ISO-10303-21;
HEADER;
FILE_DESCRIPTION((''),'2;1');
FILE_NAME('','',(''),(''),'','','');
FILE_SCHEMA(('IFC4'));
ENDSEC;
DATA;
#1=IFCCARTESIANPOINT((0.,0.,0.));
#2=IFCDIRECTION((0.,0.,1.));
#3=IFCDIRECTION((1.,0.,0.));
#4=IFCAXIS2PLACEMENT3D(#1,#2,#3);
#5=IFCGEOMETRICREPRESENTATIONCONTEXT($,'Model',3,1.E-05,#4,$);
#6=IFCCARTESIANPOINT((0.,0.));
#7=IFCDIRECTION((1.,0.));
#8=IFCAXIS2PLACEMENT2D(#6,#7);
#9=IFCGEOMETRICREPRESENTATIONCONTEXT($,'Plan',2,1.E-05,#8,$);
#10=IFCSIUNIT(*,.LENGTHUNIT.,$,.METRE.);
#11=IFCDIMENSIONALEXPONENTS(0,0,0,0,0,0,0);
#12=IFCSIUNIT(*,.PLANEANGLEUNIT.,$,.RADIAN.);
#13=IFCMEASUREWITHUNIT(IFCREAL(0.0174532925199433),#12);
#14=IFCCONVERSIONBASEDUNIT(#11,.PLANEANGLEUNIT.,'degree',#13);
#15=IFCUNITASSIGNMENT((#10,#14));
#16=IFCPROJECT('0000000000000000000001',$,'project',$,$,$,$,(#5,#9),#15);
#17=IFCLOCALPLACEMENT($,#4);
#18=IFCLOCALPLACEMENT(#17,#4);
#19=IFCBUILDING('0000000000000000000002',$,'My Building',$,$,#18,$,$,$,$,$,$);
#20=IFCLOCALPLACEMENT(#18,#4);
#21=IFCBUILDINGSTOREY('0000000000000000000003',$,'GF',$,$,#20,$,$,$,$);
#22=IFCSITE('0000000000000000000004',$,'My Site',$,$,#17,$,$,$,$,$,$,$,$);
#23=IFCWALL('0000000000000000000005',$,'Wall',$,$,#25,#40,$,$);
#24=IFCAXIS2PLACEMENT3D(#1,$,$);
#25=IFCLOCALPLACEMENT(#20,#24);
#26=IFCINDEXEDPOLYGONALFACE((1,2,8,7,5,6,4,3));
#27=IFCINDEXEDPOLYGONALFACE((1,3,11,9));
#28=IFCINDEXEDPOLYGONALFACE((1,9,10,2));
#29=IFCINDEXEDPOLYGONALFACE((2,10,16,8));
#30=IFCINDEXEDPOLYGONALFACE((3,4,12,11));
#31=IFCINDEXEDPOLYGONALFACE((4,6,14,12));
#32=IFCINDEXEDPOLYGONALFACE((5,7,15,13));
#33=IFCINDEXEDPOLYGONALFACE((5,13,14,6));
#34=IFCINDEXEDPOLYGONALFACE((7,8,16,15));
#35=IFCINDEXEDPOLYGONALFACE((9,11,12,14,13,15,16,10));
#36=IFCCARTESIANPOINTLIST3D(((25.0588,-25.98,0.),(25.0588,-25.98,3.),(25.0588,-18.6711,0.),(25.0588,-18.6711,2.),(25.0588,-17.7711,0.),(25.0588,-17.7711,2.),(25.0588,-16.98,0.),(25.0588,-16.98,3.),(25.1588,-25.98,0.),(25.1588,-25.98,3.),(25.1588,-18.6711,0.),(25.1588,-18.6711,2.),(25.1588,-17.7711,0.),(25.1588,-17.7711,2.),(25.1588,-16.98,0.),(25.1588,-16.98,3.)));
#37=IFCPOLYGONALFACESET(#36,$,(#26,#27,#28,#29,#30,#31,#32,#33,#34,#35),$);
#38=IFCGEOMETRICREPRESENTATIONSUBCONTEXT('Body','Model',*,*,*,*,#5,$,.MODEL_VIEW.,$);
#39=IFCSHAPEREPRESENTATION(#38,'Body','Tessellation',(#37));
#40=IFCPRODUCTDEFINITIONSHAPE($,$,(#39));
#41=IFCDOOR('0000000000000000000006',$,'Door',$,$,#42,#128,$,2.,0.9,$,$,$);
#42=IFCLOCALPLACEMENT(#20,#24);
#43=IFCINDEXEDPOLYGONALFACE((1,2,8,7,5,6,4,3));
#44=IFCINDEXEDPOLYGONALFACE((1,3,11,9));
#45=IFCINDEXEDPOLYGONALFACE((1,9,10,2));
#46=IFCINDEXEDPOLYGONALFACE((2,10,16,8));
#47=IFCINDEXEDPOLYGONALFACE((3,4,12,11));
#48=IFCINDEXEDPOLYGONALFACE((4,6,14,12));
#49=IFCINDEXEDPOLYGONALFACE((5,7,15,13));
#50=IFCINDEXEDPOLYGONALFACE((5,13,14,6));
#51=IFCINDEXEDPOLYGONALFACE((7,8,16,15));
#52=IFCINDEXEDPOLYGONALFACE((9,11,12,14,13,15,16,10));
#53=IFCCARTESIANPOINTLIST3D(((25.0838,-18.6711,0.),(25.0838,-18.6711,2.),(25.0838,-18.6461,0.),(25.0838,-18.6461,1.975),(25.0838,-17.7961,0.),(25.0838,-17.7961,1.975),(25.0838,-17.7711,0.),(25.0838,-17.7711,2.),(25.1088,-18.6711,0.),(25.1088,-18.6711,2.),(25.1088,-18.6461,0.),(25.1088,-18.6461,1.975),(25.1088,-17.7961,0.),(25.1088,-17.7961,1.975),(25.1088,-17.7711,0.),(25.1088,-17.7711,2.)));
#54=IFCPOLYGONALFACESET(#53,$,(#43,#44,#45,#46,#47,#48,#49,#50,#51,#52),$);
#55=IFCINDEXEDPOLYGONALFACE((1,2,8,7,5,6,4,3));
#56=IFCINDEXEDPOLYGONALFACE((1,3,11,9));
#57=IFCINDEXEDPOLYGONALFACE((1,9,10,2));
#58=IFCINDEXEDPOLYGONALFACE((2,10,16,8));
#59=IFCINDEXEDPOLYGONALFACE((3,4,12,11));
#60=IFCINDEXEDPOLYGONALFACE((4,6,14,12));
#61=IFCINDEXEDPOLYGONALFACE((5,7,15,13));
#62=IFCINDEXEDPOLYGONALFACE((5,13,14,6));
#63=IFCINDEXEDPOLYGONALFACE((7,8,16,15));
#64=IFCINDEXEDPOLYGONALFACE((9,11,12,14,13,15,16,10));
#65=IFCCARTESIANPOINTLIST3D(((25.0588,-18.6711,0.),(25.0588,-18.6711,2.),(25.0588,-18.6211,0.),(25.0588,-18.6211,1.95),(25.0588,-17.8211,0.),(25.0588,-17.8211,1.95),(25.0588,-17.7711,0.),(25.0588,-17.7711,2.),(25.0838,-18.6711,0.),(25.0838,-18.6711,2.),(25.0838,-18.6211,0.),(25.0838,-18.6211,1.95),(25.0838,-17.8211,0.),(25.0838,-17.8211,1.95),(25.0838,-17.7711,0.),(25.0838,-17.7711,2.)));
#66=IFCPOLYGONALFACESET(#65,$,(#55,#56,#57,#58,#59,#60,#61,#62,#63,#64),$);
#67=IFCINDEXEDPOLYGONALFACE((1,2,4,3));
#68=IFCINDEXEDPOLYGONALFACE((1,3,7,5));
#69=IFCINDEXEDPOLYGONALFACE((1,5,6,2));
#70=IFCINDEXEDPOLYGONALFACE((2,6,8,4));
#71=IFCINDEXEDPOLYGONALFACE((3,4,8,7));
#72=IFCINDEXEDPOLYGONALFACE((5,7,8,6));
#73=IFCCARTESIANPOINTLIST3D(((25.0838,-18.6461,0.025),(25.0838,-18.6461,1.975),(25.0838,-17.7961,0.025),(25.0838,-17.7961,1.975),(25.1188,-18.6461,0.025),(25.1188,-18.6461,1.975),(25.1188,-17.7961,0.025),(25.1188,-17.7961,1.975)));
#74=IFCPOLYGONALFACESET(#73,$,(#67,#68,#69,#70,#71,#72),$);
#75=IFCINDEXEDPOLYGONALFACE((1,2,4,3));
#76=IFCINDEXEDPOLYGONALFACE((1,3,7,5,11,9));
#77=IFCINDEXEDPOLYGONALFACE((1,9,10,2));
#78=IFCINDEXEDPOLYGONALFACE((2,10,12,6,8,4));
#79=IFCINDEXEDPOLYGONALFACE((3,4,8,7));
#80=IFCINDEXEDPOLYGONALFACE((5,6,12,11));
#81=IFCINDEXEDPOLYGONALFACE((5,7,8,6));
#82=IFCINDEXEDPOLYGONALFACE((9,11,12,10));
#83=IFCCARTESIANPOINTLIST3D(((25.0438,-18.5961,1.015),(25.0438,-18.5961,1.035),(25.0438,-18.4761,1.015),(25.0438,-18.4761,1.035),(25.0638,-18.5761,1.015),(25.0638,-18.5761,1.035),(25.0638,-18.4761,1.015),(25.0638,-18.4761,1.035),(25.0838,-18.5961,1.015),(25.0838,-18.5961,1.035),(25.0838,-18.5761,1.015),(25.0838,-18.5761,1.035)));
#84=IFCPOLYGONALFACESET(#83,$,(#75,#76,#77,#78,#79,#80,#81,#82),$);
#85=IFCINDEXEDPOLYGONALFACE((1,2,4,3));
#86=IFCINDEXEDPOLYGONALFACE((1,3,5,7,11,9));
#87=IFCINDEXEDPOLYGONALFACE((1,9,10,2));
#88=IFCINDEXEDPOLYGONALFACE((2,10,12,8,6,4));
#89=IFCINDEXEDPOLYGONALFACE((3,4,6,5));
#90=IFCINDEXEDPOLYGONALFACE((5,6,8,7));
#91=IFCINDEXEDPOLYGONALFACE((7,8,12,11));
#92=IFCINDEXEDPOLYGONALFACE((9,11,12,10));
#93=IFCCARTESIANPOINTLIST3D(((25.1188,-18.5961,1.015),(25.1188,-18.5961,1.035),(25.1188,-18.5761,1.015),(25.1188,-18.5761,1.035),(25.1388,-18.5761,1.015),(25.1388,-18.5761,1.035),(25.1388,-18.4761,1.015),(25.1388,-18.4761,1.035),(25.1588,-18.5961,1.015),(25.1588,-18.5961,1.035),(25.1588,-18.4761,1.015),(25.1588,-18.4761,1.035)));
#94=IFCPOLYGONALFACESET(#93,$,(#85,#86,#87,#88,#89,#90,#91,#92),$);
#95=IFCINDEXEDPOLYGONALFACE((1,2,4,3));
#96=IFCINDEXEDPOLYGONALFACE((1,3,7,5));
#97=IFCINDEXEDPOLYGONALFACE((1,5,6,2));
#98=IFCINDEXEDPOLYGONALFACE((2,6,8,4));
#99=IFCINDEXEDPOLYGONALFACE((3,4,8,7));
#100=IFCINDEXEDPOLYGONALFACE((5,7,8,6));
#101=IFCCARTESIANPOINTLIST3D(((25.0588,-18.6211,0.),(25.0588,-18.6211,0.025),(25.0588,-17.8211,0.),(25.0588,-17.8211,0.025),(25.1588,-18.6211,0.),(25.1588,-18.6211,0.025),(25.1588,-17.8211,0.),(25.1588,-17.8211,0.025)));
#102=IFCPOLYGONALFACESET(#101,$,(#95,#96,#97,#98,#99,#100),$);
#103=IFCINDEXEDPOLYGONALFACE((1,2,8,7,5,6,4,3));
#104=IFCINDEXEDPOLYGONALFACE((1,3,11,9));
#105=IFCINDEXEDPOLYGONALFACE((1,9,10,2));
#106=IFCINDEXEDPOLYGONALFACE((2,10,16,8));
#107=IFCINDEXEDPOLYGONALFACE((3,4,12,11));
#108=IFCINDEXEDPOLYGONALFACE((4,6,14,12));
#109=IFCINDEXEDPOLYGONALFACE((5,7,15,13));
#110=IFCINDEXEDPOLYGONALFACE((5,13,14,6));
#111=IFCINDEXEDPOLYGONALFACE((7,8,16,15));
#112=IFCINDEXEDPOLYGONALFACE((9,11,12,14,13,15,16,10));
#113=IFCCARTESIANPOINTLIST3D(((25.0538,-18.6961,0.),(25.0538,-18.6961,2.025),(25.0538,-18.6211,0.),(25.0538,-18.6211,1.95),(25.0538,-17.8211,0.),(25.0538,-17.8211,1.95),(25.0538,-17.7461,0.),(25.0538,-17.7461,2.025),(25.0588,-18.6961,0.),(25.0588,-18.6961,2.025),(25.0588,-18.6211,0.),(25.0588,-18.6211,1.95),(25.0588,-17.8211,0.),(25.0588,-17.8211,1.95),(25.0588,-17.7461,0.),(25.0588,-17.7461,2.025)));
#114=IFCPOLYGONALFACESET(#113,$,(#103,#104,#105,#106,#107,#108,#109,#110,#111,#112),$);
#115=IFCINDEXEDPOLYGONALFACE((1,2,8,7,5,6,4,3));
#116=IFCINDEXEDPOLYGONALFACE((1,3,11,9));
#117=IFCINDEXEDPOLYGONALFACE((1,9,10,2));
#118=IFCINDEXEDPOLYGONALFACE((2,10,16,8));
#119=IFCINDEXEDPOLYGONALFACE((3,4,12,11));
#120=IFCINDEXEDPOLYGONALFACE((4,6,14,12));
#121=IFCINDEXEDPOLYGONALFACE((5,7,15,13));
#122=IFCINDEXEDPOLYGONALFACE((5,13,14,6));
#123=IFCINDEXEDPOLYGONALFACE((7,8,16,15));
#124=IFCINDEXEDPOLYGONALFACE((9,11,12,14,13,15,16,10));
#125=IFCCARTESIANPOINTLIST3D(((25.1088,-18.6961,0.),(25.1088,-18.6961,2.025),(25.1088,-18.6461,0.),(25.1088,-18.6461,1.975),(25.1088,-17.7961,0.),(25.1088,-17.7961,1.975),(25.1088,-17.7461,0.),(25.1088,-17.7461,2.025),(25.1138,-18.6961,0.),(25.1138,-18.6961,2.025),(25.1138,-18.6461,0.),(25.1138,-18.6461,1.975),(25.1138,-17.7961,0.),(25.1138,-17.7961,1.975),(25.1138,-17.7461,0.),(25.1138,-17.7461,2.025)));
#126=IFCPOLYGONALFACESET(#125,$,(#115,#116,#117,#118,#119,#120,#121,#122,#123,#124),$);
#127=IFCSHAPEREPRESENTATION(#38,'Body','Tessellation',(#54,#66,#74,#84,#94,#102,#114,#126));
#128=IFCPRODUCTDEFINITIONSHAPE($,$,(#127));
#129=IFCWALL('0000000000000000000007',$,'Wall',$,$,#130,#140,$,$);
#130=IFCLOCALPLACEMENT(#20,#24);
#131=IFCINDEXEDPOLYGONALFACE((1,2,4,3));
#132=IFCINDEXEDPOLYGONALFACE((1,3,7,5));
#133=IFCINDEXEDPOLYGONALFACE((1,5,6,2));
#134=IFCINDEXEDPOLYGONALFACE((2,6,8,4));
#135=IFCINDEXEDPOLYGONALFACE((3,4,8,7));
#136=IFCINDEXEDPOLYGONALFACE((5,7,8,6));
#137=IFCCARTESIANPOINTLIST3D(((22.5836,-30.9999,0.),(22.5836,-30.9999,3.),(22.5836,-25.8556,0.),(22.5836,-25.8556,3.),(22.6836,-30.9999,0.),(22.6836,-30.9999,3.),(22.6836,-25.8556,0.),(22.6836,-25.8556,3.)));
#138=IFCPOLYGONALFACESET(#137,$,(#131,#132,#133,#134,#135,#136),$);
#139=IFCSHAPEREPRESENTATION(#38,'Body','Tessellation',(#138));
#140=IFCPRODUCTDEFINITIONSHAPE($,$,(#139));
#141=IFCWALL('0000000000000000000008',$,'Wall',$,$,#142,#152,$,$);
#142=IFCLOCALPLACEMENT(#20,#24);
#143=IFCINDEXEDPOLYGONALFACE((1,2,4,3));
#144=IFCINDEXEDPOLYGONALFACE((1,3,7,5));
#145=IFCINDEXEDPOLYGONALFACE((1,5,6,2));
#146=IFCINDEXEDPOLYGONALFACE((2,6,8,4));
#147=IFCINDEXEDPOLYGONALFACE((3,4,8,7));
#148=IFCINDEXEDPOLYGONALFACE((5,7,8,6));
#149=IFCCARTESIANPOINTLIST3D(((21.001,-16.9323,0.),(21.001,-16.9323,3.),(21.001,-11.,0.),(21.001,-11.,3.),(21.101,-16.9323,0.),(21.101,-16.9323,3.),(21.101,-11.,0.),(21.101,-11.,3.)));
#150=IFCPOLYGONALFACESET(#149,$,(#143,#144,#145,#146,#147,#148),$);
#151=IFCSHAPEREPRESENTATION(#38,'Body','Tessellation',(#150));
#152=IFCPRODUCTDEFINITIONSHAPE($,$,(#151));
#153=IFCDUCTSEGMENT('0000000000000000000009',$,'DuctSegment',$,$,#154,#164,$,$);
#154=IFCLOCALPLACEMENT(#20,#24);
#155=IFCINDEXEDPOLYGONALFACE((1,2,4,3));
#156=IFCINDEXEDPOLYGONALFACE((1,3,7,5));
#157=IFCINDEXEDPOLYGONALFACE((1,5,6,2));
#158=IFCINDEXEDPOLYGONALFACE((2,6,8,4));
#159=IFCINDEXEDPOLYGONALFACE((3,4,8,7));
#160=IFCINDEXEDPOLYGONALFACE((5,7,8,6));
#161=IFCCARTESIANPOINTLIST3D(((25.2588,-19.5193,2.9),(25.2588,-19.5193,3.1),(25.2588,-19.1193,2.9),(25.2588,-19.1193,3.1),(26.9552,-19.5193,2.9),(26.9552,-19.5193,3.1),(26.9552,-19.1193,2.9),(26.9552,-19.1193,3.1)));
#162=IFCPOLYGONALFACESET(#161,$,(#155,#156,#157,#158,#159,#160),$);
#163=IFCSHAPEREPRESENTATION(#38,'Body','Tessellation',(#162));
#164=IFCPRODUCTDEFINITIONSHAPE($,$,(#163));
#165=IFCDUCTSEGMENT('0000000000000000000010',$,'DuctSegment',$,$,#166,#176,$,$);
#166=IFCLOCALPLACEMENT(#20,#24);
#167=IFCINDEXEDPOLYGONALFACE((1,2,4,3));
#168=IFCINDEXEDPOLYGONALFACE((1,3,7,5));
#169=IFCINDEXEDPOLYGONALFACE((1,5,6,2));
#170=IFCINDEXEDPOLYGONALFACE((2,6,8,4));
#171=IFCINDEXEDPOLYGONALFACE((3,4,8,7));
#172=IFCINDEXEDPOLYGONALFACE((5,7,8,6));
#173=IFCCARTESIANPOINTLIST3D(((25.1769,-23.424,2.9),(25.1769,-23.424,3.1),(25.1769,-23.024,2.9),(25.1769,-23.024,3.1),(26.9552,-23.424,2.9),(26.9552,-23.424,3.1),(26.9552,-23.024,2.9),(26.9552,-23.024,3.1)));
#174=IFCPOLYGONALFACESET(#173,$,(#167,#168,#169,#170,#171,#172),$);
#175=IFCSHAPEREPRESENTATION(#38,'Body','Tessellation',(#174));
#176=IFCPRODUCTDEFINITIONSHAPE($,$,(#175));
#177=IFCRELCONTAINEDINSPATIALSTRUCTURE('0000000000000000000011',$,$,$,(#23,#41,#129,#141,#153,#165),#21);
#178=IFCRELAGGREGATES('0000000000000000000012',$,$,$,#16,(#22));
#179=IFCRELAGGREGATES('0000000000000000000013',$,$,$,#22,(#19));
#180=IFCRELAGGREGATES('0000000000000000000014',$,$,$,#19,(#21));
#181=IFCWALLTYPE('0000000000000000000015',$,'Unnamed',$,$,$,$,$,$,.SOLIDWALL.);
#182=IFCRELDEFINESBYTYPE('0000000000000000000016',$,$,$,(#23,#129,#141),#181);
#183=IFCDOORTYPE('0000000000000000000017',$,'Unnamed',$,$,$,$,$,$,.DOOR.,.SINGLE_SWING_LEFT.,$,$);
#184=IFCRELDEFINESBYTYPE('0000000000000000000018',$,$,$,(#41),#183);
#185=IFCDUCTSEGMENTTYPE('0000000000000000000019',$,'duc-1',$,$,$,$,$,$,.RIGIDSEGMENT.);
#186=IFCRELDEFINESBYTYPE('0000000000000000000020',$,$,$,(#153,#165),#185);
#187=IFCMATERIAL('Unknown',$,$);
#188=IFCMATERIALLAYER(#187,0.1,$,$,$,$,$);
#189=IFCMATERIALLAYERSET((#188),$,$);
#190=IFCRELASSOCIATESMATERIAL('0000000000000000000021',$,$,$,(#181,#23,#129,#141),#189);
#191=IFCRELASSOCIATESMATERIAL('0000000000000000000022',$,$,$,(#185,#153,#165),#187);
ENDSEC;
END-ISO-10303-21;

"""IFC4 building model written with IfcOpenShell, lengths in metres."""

from ifc_helpers import new_model, entity, si_unit, converted_unit, frame, origin_with_axes, origin_2d_with_axis, place, context, subcontext, project, spatial, line, indexed_curve, rectangle, outline, extrude, shape, source, transform, mapped, material, layer, layer_set, layer_usage, material_profile, profile_set, profile_usage, type_object, type_shapes, element, fill, save


model = new_model("IFC4")

# Units and contexts
model_context = context("Model", 3, precision=1e-05, world=origin_with_axes())
plan_context = context("Plan", 2, precision=1e-05, world=origin_2d_with_axis())
body_context_1 = subcontext(model_context, "Body", "Model", "MODEL_VIEW")
body_context_2 = subcontext(plan_context, "Body", "Plan", "PLAN_VIEW")
ifc_project = project(units=[si_unit("LENGTHUNIT", "METRE"), converted_unit("PLANEANGLEUNIT", "degree", entity("IfcReal", 0.0174532925199433), si_unit("PLANEANGLEUNIT", "RADIAN"), dimensions=[0, 0, 0, 0, 0, 0, 0])], contexts=[model_context, plan_context])

# Site, building, storey
site_placement = place(None, origin_with_axes())
site = spatial("IfcSite", under=ifc_project, at=site_placement, Name="My Site")
building_placement = place(site_placement, origin_with_axes())
building = spatial("IfcBuilding", under=site, at=building_placement, Name="My Building")
storey_placement = place(building_placement, origin_with_axes())
storey = spatial("IfcBuildingStorey", under=building, at=storey_placement, Name="GF")

# Shared definitions
ifc_material = material(Name="Unknown")
ifc_layer = layer(ifc_material, 0.1)
ifc_layer_set = layer_set([ifc_layer])
wall_type = type_object("IfcWallType", Name="Unnamed", PredefinedType="SOLIDWALL", material=ifc_layer_set)

# Shared definitions
shared_shape_1 = source(origin_with_axes(), body_context_1, "Body", "SweptSolid", [
    extrude(outline(indexed_curve([(0.0, 0.0), (0.9, 0.0), (0.9, 2.0), (0.0, 2.0)], segments=[line(1, 2, 3, 4, 1)])), frame((0.0, -0.6, 0.0), z_axis=(0.0, -1.0, 0.0), x_axis=(1.0, 0.0, 0.0)), (0.0, 0.0, -1.0), 1.2),
])
door_type = type_object("IfcDoorType", Name="Unnamed", OperationType="SINGLE_SWING_LEFT", PredefinedType="DOOR")
shared_shape_2 = source(origin_with_axes(), body_context_1, "Body", "SweptSolid", [
    extrude(outline(indexed_curve([(0.0, 0.0), (0.0, 2.0), (0.9, 2.0), (0.9, 0.0), (0.875, 0.0), (0.875, 1.975), (0.025, 1.975), (0.025, 0.0)], segments=[line(1, 2, 3, 4, 5, 6, 7, 8, 1)])), frame((0.0, 0.025, 0.0), z_axis=(0.0, -1.0, 0.0), x_axis=(1.0, 0.0, 0.0)), (0.0, 0.0, -1.0), 0.025),
    extrude(outline(indexed_curve([(0.0, 0.0), (0.0, 2.0), (0.9, 2.0), (0.9, 0.0), (0.85, 0.0), (0.85, 1.95), (0.05, 1.95), (0.05, 0.0)], segments=[line(1, 2, 3, 4, 5, 6, 7, 8, 1)])), frame((0.0, 0.0, 0.0), z_axis=(0.0, -1.0, 0.0), x_axis=(1.0, 0.0, 0.0)), (0.0, 0.0, -1.0), 0.025),
    extrude(outline(indexed_curve([(0.0, 0.0), (0.85, 0.0), (0.85, 0.035), (0.0, 0.035)], segments=[line(1, 2, 3, 4, 1)])), frame((0.025, 0.025, 0.025), z_axis=(0.0, 0.0, 1.0), x_axis=(1.0, 0.0, 0.0)), (0.0, 0.0, 1.0), 1.95),
    extrude(outline(indexed_curve([(0.0, 0.0), (0.0, -0.04), (-0.12, -0.04), (-0.12, -0.02), (-0.02, -0.02), (-0.02, 0.0)], segments=[line(1, 2, 3, 4, 5, 6, 1)])), frame((0.825, 0.025, 1.015), z_axis=(0.0, 0.0, 1.0), x_axis=(1.0, 0.0, 0.0)), (0.0, 0.0, 1.0), 0.02),
    extrude(outline(indexed_curve([(0.0, 0.0), (0.0, 0.04), (-0.12, 0.04), (-0.12, 0.02), (-0.02, 0.02), (-0.02, 0.0)], segments=[line(1, 2, 3, 4, 5, 6, 1)])), frame((0.825, 0.06, 1.015), z_axis=(0.0, 0.0, 1.0), x_axis=(1.0, 0.0, 0.0)), (0.0, 0.0, 1.0), 0.02),
    extrude(outline(indexed_curve([(0.0, 0.0), (0.8, 0.0), (0.8, 0.1), (0.0, 0.1)], segments=[line(1, 2, 3, 4, 1)])), frame((0.05, 0.0, 0.0), z_axis=(0.0, 0.0, 1.0), x_axis=(1.0, 0.0, 0.0)), (0.0, 0.0, 1.0), 0.025),
    extrude(outline(indexed_curve([(0.0, 0.0), (0.0, 2.025), (0.95, 2.025), (0.95, 0.0), (0.875, 0.0), (0.875, 1.95), (0.075, 1.95), (0.075, 0.0)], segments=[line(1, 2, 3, 4, 5, 6, 7, 8, 1)])), frame((-0.025, -0.005, 0.0), z_axis=(0.0, -1.0, 0.0), x_axis=(1.0, 0.0, 0.0)), (0.0, 0.0, -1.0), 0.005),
    extrude(outline(indexed_curve([(0.0, 0.0), (0.0, 2.025), (0.95, 2.025), (0.95, 0.0), (0.9, 0.0), (0.9, 1.975), (0.05, 1.975), (0.05, 0.0)], segments=[line(1, 2, 3, 4, 5, 6, 7, 8, 1)])), frame((-0.025, 0.05, 0.0), z_axis=(0.0, -1.0, 0.0), x_axis=(1.0, 0.0, 0.0)), (0.0, 0.0, -1.0), 0.005),
])
shared_shape_3 = source(origin_with_axes(), body_context_2, "Body", "Curve2D", [
    entity("IfcIndexedPolyCurve", entity("IfcCartesianPointList2D", [[0.0, 0.0], [0.0, 0.05], [0.025, 0.05], [0.025, 0.025], [0.05, 0.025], [0.05, 0.0]]), [entity("IfcLineIndex", [1, 2, 3, 4, 5, 6, 1])]),
    entity("IfcIndexedPolyCurve", entity("IfcCartesianPointList2D", [[0.9, 0.0], [0.9, 0.05], [0.875, 0.05], [0.875, 0.025], [0.85, 0.025], [0.85, 0.0]]), [entity("IfcLineIndex", [1, 2, 3, 4, 5, 6, 1])]),
    entity("IfcTrimmedCurve", entity("IfcEllipse", entity("IfcAxis2Placement2D", entity("IfcCartesianPoint", [0.06, 0.05]), entity("IfcDirection", [1.0, 0.0])), 0.815, 0.85), [entity("IfcCartesianPoint", [0.875, 0.05])], [entity("IfcCartesianPoint", [0.06, 0.9])], True, "CARTESIAN"),
    entity("IfcIndexedPolyCurve", entity("IfcCartesianPointList2D", [[0.025, 0.05], [0.06, 0.05], [0.06, 0.9], [0.025, 0.9]]), [entity("IfcLineIndex", [1, 2, 3, 4, 1])]),
])
type_shapes(door_type, [shared_shape_2, shared_shape_3])

# Wall, opening, door
ifc_layer_usage_1 = layer_usage(ifc_layer_set, "AXIS2", "POSITIVE", 0.0)
wall_1_placement = place(storey_placement, frame((25.0588, -16.98, 0.0), z_axis=(0.0, 0.0, 1.0), x_axis=(0.0, -1.0, 0.0)))
wall_1 = element("IfcWall", 1, at=wall_1_placement, inside=storey, type_object=wall_type, material=ifc_layer_usage_1, Name="Wall", context=body_context_1, shape_type="SweptSolid", body=[
    extrude(outline(indexed_curve([(0.0, 0.0), (0.0, 0.1), (9.0, 0.1), (9.0, 0.0)], segments=[line(1, 2, 3, 4, 1)])), origin_with_axes(), (0.0, 0.0, 1.0), 3.0),
])
opening_1_placement = place(wall_1_placement, frame((0.7911, 0.0, 0.0), z_axis=(0.0, 0.0, 1.0), x_axis=(1.0, 0.0, 0.0)))
opening_1 = element("IfcOpeningElement", 2, at=opening_1_placement, cuts=wall_1, PredefinedType="OPENING", context=body_context_1, shape_type="MappedRepresentation", body=[
    mapped(shared_shape_1, transform((0.0, 0.0, 0.0), x_axis=(1.0, 0.0, 0.0), y_axis=(0.0, 1.0, 0.0), z_axis=(0.0, 0.0, 1.0), scale=1.0)),
])
door_1_placement = place(opening_1_placement, frame((0.0, 0.0, 0.0), z_axis=(0.0, 0.0, 1.0), x_axis=(1.0, 0.0, 0.0)))
door_1 = element("IfcDoor", 3, at=door_1_placement, inside=storey, type_object=door_type, Name="Door", OverallHeight=2.0, OverallWidth=0.9, shapes=[
    shape(body_context_1, "Body", "MappedRepresentation", [mapped(shared_shape_2, transform((0.0, 0.0, 0.0), x_axis=(1.0, 0.0, 0.0), y_axis=(0.0, 1.0, 0.0), z_axis=(0.0, 0.0, 1.0), scale=1.0))]),
    shape(body_context_2, "Body", "MappedRepresentation", [mapped(shared_shape_3, transform((0.0, 0.0, 0.0), x_axis=(1.0, 0.0, 0.0), y_axis=(0.0, 1.0, 0.0), z_axis=(0.0, 0.0, 1.0), scale=1.0))]),
])
fill(opening_1, door_1)

# Walls
ifc_layer_usage_2 = layer_usage(ifc_layer_set, "AXIS2", "POSITIVE", 0.0)
wall_2_placement = place(storey_placement, frame((22.5836, -25.8556, 0.0), z_axis=(0.0, 0.0, 1.0), x_axis=(0.0, -1.0, 0.0)))
element("IfcWall", 4, at=wall_2_placement, inside=storey, type_object=wall_type, material=ifc_layer_usage_2, Name="Wall", context=body_context_1, shape_type="SweptSolid", body=[
    extrude(outline(indexed_curve([(0.0, 0.0), (0.0, 0.1), (5.1443, 0.1), (5.1443, 0.0)], segments=[line(1, 2, 3, 4, 1)])), origin_with_axes(), (0.0, 0.0, 1.0), 3.0),
])
ifc_layer_usage_3 = layer_usage(ifc_layer_set, "AXIS2", "POSITIVE", 0.0)
wall_3_placement = place(storey_placement, frame((21.101, -16.9323, 0.0), z_axis=(0.0, 0.0, 1.0), x_axis=(0.0, 1.0, 0.0)))
element("IfcWall", 5, at=wall_3_placement, inside=storey, type_object=wall_type, material=ifc_layer_usage_3, Name="Wall", context=body_context_1, shape_type="SweptSolid", body=[
    extrude(outline(indexed_curve([(0.0, 0.0), (0.0, 0.1), (5.9323, 0.1), (5.9323, 0.0)], segments=[line(1, 2, 3, 4, 1)])), origin_with_axes(), (0.0, 0.0, 1.0), 3.0),
])

# Duct segments
ifc_material_profile_1 = material_profile(ifc_material, rectangle(XDim=0.4, YDim=0.2))
ifc_profile_set_1 = profile_set([ifc_material_profile_1])
ifc_profile_usage_1 = profile_usage(ifc_profile_set_1, cardinal=5)
duct_segment_type = type_object("IfcDuctSegmentType", Name="duc-1", PredefinedType="RIGIDSEGMENT", material=ifc_profile_set_1)
duct_segment_1_placement = place(storey_placement, frame((25.2588, -19.3193, 3.0), z_axis=(1.0, 0.0, 0.0), x_axis=(0.0, 1.0, 0.0)))
element("IfcDuctSegment", 6, at=duct_segment_1_placement, inside=storey, type_object=duct_segment_type, material=ifc_profile_usage_1, Name="DuctSegment", context=body_context_1, shape_type="SweptSolid", body=[
    extrude(rectangle(XDim=0.4, YDim=0.2), origin_with_axes(), (0.0, 0.0, 1.0), 1.6963),
])
ifc_profile_usage_2 = profile_usage(ifc_profile_set_1, cardinal=5)
duct_segment_2_placement = place(storey_placement, frame((25.1769, -23.224, 3.0), z_axis=(1.0, 0.0, 0.0), x_axis=(0.0, 1.0, 0.0)))
element("IfcDuctSegment", 7, at=duct_segment_2_placement, inside=storey, type_object=duct_segment_type, material=ifc_profile_usage_2, Name="DuctSegment", context=body_context_1, shape_type="SweptSolid", body=[
    extrude(rectangle(XDim=0.4, YDim=0.2), origin_with_axes(), (0.0, 0.0, 1.0), 1.7783),
])

save(model, "model.ifc")
